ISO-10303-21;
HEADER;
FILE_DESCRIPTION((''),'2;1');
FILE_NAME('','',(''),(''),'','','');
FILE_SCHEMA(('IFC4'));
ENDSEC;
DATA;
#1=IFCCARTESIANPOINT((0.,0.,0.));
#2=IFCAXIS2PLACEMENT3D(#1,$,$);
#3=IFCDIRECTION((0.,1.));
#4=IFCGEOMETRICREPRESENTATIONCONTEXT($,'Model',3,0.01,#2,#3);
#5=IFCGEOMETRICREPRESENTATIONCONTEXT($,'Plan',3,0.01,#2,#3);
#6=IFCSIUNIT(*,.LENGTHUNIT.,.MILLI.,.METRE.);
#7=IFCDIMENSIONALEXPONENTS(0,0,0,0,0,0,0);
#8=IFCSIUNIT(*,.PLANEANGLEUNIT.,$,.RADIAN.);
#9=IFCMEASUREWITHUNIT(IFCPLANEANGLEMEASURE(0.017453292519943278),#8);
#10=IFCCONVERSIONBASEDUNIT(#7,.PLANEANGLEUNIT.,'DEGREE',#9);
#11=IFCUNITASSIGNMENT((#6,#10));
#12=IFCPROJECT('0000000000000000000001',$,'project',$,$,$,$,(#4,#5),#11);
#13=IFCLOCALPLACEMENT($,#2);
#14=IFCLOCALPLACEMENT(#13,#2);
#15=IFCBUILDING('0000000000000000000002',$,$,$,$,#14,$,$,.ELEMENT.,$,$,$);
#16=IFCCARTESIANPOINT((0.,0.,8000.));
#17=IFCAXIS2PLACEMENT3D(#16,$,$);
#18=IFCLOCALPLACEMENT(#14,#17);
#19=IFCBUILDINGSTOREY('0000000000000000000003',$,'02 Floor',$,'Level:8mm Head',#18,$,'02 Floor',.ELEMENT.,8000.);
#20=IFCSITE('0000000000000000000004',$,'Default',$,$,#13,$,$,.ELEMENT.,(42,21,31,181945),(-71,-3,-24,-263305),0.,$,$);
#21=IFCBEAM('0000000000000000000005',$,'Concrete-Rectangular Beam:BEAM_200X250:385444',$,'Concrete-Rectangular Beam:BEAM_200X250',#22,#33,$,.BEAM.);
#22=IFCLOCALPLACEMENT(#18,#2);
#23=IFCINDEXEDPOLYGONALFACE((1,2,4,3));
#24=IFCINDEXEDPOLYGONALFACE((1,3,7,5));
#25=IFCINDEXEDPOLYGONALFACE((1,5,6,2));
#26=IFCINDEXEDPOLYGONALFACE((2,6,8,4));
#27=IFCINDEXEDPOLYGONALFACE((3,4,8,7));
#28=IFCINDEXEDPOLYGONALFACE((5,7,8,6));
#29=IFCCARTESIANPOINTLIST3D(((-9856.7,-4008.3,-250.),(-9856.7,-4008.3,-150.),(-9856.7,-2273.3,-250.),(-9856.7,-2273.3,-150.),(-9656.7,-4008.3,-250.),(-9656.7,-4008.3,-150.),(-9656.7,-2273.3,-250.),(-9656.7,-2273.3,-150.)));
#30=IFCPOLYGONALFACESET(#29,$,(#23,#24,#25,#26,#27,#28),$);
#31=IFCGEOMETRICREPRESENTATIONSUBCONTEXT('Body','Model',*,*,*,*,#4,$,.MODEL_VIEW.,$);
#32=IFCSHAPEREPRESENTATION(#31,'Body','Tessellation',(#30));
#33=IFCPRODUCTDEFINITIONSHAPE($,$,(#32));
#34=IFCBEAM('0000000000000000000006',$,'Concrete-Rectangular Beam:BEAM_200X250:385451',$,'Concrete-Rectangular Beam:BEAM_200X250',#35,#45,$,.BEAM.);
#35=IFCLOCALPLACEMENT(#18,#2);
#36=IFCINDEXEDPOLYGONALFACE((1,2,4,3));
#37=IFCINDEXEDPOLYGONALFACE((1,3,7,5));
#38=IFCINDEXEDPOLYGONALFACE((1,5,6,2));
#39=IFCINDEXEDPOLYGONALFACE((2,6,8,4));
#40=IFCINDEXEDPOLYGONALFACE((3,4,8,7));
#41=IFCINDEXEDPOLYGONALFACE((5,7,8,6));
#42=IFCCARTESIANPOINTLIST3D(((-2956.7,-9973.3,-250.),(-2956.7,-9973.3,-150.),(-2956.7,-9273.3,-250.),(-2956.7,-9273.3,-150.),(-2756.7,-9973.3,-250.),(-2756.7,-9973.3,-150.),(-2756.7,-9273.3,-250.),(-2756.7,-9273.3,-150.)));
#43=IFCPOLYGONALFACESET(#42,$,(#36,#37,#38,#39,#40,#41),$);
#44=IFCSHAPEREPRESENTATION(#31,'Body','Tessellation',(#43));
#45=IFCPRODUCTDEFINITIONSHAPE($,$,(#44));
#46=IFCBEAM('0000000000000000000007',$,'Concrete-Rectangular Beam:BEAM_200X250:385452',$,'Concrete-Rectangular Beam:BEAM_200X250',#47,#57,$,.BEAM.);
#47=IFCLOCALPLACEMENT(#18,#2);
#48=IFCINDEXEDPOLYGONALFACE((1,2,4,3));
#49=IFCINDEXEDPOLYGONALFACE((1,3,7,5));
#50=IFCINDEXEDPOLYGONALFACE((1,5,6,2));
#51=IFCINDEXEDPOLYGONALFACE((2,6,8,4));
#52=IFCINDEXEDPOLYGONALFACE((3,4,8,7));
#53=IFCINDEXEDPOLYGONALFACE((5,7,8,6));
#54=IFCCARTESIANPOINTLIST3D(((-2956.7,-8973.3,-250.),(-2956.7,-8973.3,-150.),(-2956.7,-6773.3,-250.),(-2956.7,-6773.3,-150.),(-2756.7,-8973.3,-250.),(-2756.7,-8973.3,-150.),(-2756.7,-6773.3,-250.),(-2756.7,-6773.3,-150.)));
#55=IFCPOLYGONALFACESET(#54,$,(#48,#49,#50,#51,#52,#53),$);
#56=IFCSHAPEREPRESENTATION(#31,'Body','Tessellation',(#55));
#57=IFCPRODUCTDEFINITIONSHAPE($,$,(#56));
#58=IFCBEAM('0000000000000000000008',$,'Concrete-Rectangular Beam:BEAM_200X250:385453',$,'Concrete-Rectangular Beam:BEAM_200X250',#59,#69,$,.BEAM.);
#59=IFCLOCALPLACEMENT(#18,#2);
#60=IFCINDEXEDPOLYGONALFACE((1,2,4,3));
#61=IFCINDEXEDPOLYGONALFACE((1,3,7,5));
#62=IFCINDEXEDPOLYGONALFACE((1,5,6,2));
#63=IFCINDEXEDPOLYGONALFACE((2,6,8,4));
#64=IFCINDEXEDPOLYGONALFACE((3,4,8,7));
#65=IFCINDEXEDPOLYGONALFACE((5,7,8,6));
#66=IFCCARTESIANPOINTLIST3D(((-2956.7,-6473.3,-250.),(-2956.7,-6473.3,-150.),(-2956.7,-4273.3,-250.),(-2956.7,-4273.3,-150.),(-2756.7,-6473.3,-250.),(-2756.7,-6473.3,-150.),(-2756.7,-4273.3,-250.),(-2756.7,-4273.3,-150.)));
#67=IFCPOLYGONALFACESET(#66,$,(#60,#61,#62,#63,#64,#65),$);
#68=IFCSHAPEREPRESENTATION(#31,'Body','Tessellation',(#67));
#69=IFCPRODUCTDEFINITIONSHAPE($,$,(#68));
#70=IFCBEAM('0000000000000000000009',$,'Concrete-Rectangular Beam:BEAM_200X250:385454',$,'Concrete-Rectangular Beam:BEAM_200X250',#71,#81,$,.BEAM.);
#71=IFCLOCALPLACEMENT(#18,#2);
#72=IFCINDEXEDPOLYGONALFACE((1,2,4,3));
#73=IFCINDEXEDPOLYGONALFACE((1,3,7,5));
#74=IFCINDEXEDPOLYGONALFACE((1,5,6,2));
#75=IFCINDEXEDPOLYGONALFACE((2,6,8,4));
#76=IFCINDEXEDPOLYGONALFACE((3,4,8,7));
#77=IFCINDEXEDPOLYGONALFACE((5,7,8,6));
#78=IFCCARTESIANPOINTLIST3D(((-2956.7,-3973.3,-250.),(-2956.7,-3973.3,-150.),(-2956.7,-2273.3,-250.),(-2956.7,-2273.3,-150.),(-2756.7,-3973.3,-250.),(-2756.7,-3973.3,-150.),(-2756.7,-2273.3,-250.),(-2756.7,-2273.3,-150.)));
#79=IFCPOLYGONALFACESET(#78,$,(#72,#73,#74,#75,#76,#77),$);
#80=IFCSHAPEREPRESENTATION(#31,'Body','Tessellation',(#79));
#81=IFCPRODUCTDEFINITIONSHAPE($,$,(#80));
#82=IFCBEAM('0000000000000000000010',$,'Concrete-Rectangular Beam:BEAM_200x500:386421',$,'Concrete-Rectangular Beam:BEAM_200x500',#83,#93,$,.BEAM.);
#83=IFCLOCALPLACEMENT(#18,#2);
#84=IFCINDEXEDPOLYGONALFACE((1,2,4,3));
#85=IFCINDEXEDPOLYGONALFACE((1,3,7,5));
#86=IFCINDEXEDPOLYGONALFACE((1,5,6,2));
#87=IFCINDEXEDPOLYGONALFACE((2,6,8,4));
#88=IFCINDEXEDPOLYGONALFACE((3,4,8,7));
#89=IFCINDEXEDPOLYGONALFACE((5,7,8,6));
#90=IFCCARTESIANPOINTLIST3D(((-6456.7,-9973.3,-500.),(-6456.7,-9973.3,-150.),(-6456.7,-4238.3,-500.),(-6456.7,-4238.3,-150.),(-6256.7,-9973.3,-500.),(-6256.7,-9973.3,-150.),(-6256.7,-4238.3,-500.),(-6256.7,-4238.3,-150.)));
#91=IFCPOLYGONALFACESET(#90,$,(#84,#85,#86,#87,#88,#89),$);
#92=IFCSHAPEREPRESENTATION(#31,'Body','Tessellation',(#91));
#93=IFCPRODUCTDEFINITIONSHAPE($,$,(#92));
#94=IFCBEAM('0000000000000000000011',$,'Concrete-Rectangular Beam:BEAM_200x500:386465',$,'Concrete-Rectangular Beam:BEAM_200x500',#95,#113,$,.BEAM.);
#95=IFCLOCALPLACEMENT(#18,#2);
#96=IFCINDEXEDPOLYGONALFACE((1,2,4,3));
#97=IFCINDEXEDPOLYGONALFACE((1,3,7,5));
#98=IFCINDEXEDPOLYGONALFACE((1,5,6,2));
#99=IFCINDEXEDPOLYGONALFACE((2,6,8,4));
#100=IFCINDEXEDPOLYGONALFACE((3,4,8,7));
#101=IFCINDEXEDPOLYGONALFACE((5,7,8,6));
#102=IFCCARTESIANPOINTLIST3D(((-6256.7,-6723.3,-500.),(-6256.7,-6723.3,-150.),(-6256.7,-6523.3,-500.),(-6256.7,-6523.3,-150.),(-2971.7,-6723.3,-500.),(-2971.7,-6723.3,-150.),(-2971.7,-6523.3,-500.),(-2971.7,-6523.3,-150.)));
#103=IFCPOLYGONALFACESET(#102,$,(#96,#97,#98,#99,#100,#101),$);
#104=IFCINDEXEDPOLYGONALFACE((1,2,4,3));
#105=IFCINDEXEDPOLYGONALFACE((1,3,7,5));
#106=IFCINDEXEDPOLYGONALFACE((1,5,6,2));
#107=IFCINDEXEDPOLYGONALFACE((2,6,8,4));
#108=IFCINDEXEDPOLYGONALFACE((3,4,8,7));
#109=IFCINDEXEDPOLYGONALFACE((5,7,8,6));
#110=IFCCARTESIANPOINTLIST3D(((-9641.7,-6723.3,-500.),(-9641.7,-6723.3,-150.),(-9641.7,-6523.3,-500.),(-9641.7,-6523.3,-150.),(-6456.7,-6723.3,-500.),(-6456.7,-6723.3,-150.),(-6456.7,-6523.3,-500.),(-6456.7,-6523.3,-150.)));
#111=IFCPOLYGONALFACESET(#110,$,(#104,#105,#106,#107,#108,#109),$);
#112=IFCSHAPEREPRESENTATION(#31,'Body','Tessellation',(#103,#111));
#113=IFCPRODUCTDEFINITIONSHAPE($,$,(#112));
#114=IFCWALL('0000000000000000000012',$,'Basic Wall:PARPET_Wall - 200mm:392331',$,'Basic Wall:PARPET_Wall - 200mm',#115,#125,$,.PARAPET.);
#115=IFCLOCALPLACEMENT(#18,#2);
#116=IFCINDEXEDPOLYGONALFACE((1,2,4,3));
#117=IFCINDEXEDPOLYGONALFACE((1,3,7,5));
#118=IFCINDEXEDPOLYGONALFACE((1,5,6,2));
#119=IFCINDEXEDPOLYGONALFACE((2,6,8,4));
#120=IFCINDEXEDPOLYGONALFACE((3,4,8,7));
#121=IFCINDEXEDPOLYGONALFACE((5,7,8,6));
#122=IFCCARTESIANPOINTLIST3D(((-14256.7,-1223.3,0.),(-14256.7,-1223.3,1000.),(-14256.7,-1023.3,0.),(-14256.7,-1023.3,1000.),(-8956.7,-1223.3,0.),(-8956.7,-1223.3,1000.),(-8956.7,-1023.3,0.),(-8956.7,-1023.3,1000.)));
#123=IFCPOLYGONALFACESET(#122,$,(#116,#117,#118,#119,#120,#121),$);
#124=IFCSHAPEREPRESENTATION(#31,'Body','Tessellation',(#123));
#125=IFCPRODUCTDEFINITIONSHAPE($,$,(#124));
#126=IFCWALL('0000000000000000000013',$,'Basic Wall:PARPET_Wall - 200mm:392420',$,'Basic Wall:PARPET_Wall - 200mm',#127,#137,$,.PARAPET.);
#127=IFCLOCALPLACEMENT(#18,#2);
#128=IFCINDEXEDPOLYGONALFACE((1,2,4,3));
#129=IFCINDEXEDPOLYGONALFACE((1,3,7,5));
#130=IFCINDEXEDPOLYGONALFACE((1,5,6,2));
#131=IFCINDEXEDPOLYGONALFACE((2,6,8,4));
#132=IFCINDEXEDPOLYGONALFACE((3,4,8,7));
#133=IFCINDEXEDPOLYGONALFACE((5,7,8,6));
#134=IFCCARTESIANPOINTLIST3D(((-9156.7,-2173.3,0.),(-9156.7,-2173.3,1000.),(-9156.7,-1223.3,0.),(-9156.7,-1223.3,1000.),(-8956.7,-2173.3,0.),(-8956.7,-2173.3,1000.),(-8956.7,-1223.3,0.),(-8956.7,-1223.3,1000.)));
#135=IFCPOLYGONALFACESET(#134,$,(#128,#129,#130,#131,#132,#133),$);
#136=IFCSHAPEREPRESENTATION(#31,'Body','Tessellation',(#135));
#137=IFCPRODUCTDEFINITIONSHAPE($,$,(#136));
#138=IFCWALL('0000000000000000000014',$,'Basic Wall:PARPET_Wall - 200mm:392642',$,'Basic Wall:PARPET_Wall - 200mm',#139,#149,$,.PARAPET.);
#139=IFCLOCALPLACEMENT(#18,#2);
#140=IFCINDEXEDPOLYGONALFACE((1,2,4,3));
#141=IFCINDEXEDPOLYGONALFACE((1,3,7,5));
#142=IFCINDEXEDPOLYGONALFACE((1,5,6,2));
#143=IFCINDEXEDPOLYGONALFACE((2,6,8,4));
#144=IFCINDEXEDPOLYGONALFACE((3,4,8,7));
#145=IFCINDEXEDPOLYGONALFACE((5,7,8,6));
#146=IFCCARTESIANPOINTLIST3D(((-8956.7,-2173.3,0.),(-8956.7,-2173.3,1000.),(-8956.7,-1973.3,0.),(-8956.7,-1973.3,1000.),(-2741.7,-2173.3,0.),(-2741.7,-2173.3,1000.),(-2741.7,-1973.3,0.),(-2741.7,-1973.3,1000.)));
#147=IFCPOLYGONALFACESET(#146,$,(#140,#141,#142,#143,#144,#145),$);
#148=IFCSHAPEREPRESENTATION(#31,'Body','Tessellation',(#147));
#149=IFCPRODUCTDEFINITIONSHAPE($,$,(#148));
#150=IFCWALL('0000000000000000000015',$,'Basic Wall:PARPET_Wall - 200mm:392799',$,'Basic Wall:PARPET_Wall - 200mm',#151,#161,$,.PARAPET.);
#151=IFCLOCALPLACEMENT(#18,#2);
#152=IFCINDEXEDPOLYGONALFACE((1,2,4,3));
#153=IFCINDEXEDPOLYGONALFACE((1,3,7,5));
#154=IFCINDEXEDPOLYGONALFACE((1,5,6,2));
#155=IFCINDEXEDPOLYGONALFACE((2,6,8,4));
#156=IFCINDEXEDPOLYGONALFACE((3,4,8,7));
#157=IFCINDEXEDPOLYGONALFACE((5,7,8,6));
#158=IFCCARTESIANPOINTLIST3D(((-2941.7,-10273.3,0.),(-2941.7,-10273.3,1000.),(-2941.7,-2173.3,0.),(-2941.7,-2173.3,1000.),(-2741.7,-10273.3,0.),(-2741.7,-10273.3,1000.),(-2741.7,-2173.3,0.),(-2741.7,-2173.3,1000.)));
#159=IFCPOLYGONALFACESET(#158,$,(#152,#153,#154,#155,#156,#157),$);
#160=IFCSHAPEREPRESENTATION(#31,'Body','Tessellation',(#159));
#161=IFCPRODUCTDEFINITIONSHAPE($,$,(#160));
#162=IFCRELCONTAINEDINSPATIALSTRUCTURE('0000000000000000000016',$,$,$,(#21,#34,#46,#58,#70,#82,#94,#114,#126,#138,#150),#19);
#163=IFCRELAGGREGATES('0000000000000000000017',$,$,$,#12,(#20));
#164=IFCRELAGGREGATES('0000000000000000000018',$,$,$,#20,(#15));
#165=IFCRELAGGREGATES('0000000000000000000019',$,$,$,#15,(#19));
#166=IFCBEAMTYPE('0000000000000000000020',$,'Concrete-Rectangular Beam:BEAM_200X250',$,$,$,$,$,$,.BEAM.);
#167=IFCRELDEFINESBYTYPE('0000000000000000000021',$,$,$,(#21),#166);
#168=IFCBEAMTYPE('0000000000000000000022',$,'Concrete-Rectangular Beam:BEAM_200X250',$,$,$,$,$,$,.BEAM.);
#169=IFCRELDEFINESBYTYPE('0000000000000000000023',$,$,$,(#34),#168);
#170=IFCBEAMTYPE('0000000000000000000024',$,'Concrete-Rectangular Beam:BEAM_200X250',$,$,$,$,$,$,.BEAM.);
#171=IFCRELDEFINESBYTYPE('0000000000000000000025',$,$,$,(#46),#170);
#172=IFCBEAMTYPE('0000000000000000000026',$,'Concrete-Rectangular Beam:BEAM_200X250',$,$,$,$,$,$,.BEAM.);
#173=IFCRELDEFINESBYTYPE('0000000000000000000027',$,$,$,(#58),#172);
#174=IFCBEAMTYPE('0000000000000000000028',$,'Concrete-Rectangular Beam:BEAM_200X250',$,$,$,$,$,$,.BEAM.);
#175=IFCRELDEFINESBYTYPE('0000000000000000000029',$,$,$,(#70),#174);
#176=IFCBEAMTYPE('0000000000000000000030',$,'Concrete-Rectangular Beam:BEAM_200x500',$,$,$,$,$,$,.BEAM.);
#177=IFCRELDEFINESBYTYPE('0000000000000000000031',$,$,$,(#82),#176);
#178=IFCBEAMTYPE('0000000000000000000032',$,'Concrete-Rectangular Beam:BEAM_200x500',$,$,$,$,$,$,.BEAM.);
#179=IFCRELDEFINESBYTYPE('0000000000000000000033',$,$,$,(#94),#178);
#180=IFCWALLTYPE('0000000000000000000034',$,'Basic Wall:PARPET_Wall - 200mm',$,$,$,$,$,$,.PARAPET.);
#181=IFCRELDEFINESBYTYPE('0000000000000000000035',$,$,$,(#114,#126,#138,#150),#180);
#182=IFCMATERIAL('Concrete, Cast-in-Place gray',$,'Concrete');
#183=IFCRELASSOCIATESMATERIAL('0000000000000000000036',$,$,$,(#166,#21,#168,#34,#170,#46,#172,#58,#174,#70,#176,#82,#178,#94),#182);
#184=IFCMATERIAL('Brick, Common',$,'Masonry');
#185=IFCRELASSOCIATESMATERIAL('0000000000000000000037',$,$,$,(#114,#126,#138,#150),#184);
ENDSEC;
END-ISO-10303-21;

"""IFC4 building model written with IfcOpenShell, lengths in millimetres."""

from ifc_helpers import new_model, entity, si_unit, converted_unit, direction, frame, origin, place, context, subcontext, project, spatial, indexed_curve, outline, extrude, source, transform, mapped, material, type_object, type_shapes, element, save


model = new_model("IFC4")

# Units and contexts
model_context = context("Model", 3, precision=0.01, world=origin(), true_north=direction((0.0, 1.0)))
plan_context = context("Plan", 3, precision=0.01, world=origin(), true_north=direction((0.0, 1.0)))
body_context = subcontext(model_context, "Body", "Model", "MODEL_VIEW")
ifc_project = project(units=[si_unit("LENGTHUNIT", "METRE", prefix="MILLI"), converted_unit("PLANEANGLEUNIT", "DEGREE", entity("IfcPlaneAngleMeasure", 0.017453292519943278), si_unit("PLANEANGLEUNIT", "RADIAN"), dimensions=[0, 0, 0, 0, 0, 0, 0])], contexts=[model_context, plan_context])

# Site, building, storey
site_placement = place(None, origin())
site = spatial("IfcSite", under=ifc_project, at=site_placement, Name="Default", CompositionType="ELEMENT", RefLatitude=(42, 21, 31, 181945), RefLongitude=(-71, -3, -24, -263305), RefElevation=0.0)
building_placement = place(site_placement, origin())
building = spatial("IfcBuilding", under=site, at=building_placement, CompositionType="ELEMENT")
storey_placement = place(building_placement, frame((0.0, 0.0, 8000.0)))
storey = spatial("IfcBuildingStorey", under=building, at=storey_placement, Name="02 Floor", ObjectType="Level:8mm Head", LongName="02 Floor", CompositionType="ELEMENT", Elevation=8000.0)

# Beams
ifc_material_1 = material(Name="Concrete, Cast-in-Place gray", Category="Concrete")
beam_type_1 = type_object("IfcBeamType", Name="Concrete-Rectangular Beam:BEAM_200X250", PredefinedType="BEAM", material=ifc_material_1)
shared_shape_1 = source(origin(), body_context, "Body", "SweptSolid", [
    extrude(outline(indexed_curve([(-100.0, -50.0), (100.0, -50.0), (100.0, 50.0), (-100.0, 50.0), (-100.0, -50.0)], self_intersect=False)), frame((-9756.7, -4008.3, 7800.0), z_axis=(0.0, 1.0, 0.0), x_axis=(-1.0, 0.0, 0.0)), (0.0, 0.0, 1.0), 1735.0),
])
type_shapes(beam_type_1, [shared_shape_1])
beam_1_placement = place(storey_placement, frame((0.0, 0.0, -8000.0)))
element("IfcBeam", 1, at=beam_1_placement, inside=storey, type_object=beam_type_1, material=ifc_material_1, Name="Concrete-Rectangular Beam:BEAM_200X250:385444", ObjectType="Concrete-Rectangular Beam:BEAM_200X250", PredefinedType="BEAM", context=body_context, shape_type="MappedRepresentation", body=[
    mapped(shared_shape_1, transform((0.0, 0.0, 0.0), scale=1.0)),
])
beam_type_2 = type_object("IfcBeamType", Name="Concrete-Rectangular Beam:BEAM_200X250", PredefinedType="BEAM", material=ifc_material_1)
shared_shape_2 = source(origin(), body_context, "Body", "SweptSolid", [
    extrude(outline(indexed_curve([(-100.0, -50.0), (100.0, -50.0), (100.0, 50.0), (-100.0, 50.0), (-100.0, -50.0)], self_intersect=False)), frame((-2856.7, -9973.3, 7800.0), z_axis=(0.0, 1.0, 0.0), x_axis=(-1.0, 0.0, 0.0)), (0.0, 0.0, 1.0), 700.0),
])
type_shapes(beam_type_2, [shared_shape_2])
beam_2_placement = place(storey_placement, frame((0.0, 0.0, -8000.0)))
element("IfcBeam", 2, at=beam_2_placement, inside=storey, type_object=beam_type_2, material=ifc_material_1, Name="Concrete-Rectangular Beam:BEAM_200X250:385451", ObjectType="Concrete-Rectangular Beam:BEAM_200X250", PredefinedType="BEAM", context=body_context, shape_type="MappedRepresentation", body=[
    mapped(shared_shape_2, transform((0.0, 0.0, 0.0), scale=1.0)),
])
beam_type_3 = type_object("IfcBeamType", Name="Concrete-Rectangular Beam:BEAM_200X250", PredefinedType="BEAM", material=ifc_material_1)
shared_shape_3 = source(origin(), body_context, "Body", "SweptSolid", [
    extrude(outline(indexed_curve([(-100.0, -50.0), (100.0, -50.0), (100.0, 50.0), (-100.0, 50.0), (-100.0, -50.0)], self_intersect=False)), frame((-2856.7, -8973.3, 7800.0), z_axis=(0.0, 1.0, 0.0), x_axis=(-1.0, 0.0, 0.0)), (0.0, 0.0, 1.0), 2200.0),
])
type_shapes(beam_type_3, [shared_shape_3])
beam_3_placement = place(storey_placement, frame((0.0, 0.0, -8000.0)))
element("IfcBeam", 3, at=beam_3_placement, inside=storey, type_object=beam_type_3, material=ifc_material_1, Name="Concrete-Rectangular Beam:BEAM_200X250:385452", ObjectType="Concrete-Rectangular Beam:BEAM_200X250", PredefinedType="BEAM", context=body_context, shape_type="MappedRepresentation", body=[
    mapped(shared_shape_3, transform((0.0, 0.0, 0.0), scale=1.0)),
])
beam_type_4 = type_object("IfcBeamType", Name="Concrete-Rectangular Beam:BEAM_200X250", PredefinedType="BEAM", material=ifc_material_1)
shared_shape_4 = source(origin(), body_context, "Body", "SweptSolid", [
    extrude(outline(indexed_curve([(-100.0, -50.0), (100.0, -50.0), (100.0, 50.0), (-100.0, 50.0), (-100.0, -50.0)], self_intersect=False)), frame((-2856.7, -6473.3, 7800.0), z_axis=(0.0, 1.0, 0.0), x_axis=(-1.0, 0.0, 0.0)), (0.0, 0.0, 1.0), 2200.0),
])
type_shapes(beam_type_4, [shared_shape_4])
beam_4_placement = place(storey_placement, frame((0.0, 0.0, -8000.0)))
element("IfcBeam", 4, at=beam_4_placement, inside=storey, type_object=beam_type_4, material=ifc_material_1, Name="Concrete-Rectangular Beam:BEAM_200X250:385453", ObjectType="Concrete-Rectangular Beam:BEAM_200X250", PredefinedType="BEAM", context=body_context, shape_type="MappedRepresentation", body=[
    mapped(shared_shape_4, transform((0.0, 0.0, 0.0), scale=1.0)),
])
beam_type_5 = type_object("IfcBeamType", Name="Concrete-Rectangular Beam:BEAM_200X250", PredefinedType="BEAM", material=ifc_material_1)
shared_shape_5 = source(origin(), body_context, "Body", "SweptSolid", [
    extrude(outline(indexed_curve([(-100.0, -50.0), (100.0, -50.0), (100.0, 50.0), (-100.0, 50.0), (-100.0, -50.0)], self_intersect=False)), frame((-2856.7, -3973.3, 7800.0), z_axis=(0.0, 1.0, 0.0), x_axis=(-1.0, 0.0, 0.0)), (0.0, 0.0, 1.0), 1700.0),
])
type_shapes(beam_type_5, [shared_shape_5])
beam_5_placement = place(storey_placement, frame((0.0, 0.0, -8000.0)))
element("IfcBeam", 5, at=beam_5_placement, inside=storey, type_object=beam_type_5, material=ifc_material_1, Name="Concrete-Rectangular Beam:BEAM_200X250:385454", ObjectType="Concrete-Rectangular Beam:BEAM_200X250", PredefinedType="BEAM", context=body_context, shape_type="MappedRepresentation", body=[
    mapped(shared_shape_5, transform((0.0, 0.0, 0.0), scale=1.0)),
])
beam_type_6 = type_object("IfcBeamType", Name="Concrete-Rectangular Beam:BEAM_200x500", PredefinedType="BEAM", material=ifc_material_1)
shared_shape_6 = source(origin(), body_context, "Body", "SweptSolid", [
    extrude(outline(indexed_curve([(-100.0, -175.0), (100.0, -175.0), (100.0, 175.0), (-100.0, 175.0), (-100.0, -175.0)], self_intersect=False)), frame((-6356.7, -4238.3, 7675.0), z_axis=(0.0, -1.0, 0.0), x_axis=(-1.0, 0.0, 0.0)), (0.0, 0.0, 1.0), 5735.0),
])
type_shapes(beam_type_6, [shared_shape_6])
beam_6_placement = place(storey_placement, frame((0.0, 0.0, -8000.0)))
element("IfcBeam", 6, at=beam_6_placement, inside=storey, type_object=beam_type_6, material=ifc_material_1, Name="Concrete-Rectangular Beam:BEAM_200x500:386421", ObjectType="Concrete-Rectangular Beam:BEAM_200x500", PredefinedType="BEAM", context=body_context, shape_type="MappedRepresentation", body=[
    mapped(shared_shape_6, transform((0.0, 0.0, 0.0), scale=1.0)),
])
beam_type_7 = type_object("IfcBeamType", Name="Concrete-Rectangular Beam:BEAM_200x500", PredefinedType="BEAM", material=ifc_material_1)
shared_shape_7 = source(origin(), body_context, "Body", "SweptSolid", [
    extrude(outline(indexed_curve([(-175.0, -100.0), (175.0, -100.0), (175.0, 100.0), (-175.0, 100.0), (-175.0, -100.0)], self_intersect=False)), frame((-6256.7, -6623.3, 7675.0), z_axis=(1.0, 0.0, 0.0), x_axis=(0.0, 0.0, -1.0)), (0.0, 0.0, 1.0), 3285.0),
    extrude(outline(indexed_curve([(-175.0, -100.0), (175.0, -100.0), (175.0, 100.0), (-175.0, 100.0), (-175.0, -100.0)], self_intersect=False)), frame((-9641.7, -6623.3, 7675.0), z_axis=(1.0, 0.0, 0.0), x_axis=(0.0, 0.0, -1.0)), (0.0, 0.0, 1.0), 3185.0),
])
type_shapes(beam_type_7, [shared_shape_7])
beam_7_placement = place(storey_placement, frame((0.0, 0.0, -8000.0)))
element("IfcBeam", 7, at=beam_7_placement, inside=storey, type_object=beam_type_7, material=ifc_material_1, Name="Concrete-Rectangular Beam:BEAM_200x500:386465", ObjectType="Concrete-Rectangular Beam:BEAM_200x500", PredefinedType="BEAM", context=body_context, shape_type="MappedRepresentation", body=[
    mapped(shared_shape_7, transform((0.0, 0.0, 0.0), scale=1.0)),
])

# Walls
ifc_material_2 = material(Name="Brick, Common", Category="Masonry")
wall_type = type_object("IfcWallType", Name="Basic Wall:PARPET_Wall - 200mm", PredefinedType="PARAPET")
wall_1_placement = place(storey_placement, frame((-14256.7, -1123.3, 0.0)))
element("IfcWall", 8, at=wall_1_placement, inside=storey, type_object=wall_type, material=ifc_material_2, Name="Basic Wall:PARPET_Wall - 200mm:392331", ObjectType="Basic Wall:PARPET_Wall - 200mm", PredefinedType="PARAPET", context=body_context, shape_type="SweptSolid", body=[
    extrude(outline(indexed_curve([(5300.0, 100.0), (0.0, 100.0), (0.0, -100.0), (5300.0, -100.0), (5300.0, 100.0)], self_intersect=False)), origin(), (0.0, 0.0, 1.0), 1000.0),
])
wall_2_placement = place(storey_placement, frame((-9056.7, -1223.3, 0.0), z_axis=(0.0, 0.0, 1.0), x_axis=(0.0, -1.0, 0.0)))
element("IfcWall", 9, at=wall_2_placement, inside=storey, type_object=wall_type, material=ifc_material_2, Name="Basic Wall:PARPET_Wall - 200mm:392420", ObjectType="Basic Wall:PARPET_Wall - 200mm", PredefinedType="PARAPET", context=body_context, shape_type="SweptSolid", body=[
    extrude(outline(indexed_curve([(950.0, 100.0), (0.0, 100.0), (0.0, -100.0), (950.0, -100.0), (950.0, 100.0)], self_intersect=False)), origin(), (0.0, 0.0, 1.0), 1000.0),
])
wall_3_placement = place(storey_placement, frame((-8956.7, -2073.3, 0.0)))
element("IfcWall", 10, at=wall_3_placement, inside=storey, type_object=wall_type, material=ifc_material_2, Name="Basic Wall:PARPET_Wall - 200mm:392642", ObjectType="Basic Wall:PARPET_Wall - 200mm", PredefinedType="PARAPET", context=body_context, shape_type="SweptSolid", body=[
    extrude(outline(indexed_curve([(6215.0, 100.0), (0.0, 100.0), (0.0, -100.0), (6215.0, -100.0), (6215.0, 100.0)], self_intersect=False)), origin(), (0.0, 0.0, 1.0), 1000.0),
])
wall_4_placement = place(storey_placement, frame((-2841.7, -2173.3, 0.0), z_axis=(0.0, 0.0, 1.0), x_axis=(0.0, -1.0, 0.0)))
element("IfcWall", 11, at=wall_4_placement, inside=storey, type_object=wall_type, material=ifc_material_2, Name="Basic Wall:PARPET_Wall - 200mm:392799", ObjectType="Basic Wall:PARPET_Wall - 200mm", PredefinedType="PARAPET", context=body_context, shape_type="SweptSolid", body=[
    extrude(outline(indexed_curve([(8100.0, 100.0), (0.0, 100.0), (0.0, -100.0), (8100.0, -100.0), (8100.0, 100.0)], self_intersect=False)), origin(), (0.0, 0.0, 1.0), 1000.0),
])

save(model, "model.ifc")
